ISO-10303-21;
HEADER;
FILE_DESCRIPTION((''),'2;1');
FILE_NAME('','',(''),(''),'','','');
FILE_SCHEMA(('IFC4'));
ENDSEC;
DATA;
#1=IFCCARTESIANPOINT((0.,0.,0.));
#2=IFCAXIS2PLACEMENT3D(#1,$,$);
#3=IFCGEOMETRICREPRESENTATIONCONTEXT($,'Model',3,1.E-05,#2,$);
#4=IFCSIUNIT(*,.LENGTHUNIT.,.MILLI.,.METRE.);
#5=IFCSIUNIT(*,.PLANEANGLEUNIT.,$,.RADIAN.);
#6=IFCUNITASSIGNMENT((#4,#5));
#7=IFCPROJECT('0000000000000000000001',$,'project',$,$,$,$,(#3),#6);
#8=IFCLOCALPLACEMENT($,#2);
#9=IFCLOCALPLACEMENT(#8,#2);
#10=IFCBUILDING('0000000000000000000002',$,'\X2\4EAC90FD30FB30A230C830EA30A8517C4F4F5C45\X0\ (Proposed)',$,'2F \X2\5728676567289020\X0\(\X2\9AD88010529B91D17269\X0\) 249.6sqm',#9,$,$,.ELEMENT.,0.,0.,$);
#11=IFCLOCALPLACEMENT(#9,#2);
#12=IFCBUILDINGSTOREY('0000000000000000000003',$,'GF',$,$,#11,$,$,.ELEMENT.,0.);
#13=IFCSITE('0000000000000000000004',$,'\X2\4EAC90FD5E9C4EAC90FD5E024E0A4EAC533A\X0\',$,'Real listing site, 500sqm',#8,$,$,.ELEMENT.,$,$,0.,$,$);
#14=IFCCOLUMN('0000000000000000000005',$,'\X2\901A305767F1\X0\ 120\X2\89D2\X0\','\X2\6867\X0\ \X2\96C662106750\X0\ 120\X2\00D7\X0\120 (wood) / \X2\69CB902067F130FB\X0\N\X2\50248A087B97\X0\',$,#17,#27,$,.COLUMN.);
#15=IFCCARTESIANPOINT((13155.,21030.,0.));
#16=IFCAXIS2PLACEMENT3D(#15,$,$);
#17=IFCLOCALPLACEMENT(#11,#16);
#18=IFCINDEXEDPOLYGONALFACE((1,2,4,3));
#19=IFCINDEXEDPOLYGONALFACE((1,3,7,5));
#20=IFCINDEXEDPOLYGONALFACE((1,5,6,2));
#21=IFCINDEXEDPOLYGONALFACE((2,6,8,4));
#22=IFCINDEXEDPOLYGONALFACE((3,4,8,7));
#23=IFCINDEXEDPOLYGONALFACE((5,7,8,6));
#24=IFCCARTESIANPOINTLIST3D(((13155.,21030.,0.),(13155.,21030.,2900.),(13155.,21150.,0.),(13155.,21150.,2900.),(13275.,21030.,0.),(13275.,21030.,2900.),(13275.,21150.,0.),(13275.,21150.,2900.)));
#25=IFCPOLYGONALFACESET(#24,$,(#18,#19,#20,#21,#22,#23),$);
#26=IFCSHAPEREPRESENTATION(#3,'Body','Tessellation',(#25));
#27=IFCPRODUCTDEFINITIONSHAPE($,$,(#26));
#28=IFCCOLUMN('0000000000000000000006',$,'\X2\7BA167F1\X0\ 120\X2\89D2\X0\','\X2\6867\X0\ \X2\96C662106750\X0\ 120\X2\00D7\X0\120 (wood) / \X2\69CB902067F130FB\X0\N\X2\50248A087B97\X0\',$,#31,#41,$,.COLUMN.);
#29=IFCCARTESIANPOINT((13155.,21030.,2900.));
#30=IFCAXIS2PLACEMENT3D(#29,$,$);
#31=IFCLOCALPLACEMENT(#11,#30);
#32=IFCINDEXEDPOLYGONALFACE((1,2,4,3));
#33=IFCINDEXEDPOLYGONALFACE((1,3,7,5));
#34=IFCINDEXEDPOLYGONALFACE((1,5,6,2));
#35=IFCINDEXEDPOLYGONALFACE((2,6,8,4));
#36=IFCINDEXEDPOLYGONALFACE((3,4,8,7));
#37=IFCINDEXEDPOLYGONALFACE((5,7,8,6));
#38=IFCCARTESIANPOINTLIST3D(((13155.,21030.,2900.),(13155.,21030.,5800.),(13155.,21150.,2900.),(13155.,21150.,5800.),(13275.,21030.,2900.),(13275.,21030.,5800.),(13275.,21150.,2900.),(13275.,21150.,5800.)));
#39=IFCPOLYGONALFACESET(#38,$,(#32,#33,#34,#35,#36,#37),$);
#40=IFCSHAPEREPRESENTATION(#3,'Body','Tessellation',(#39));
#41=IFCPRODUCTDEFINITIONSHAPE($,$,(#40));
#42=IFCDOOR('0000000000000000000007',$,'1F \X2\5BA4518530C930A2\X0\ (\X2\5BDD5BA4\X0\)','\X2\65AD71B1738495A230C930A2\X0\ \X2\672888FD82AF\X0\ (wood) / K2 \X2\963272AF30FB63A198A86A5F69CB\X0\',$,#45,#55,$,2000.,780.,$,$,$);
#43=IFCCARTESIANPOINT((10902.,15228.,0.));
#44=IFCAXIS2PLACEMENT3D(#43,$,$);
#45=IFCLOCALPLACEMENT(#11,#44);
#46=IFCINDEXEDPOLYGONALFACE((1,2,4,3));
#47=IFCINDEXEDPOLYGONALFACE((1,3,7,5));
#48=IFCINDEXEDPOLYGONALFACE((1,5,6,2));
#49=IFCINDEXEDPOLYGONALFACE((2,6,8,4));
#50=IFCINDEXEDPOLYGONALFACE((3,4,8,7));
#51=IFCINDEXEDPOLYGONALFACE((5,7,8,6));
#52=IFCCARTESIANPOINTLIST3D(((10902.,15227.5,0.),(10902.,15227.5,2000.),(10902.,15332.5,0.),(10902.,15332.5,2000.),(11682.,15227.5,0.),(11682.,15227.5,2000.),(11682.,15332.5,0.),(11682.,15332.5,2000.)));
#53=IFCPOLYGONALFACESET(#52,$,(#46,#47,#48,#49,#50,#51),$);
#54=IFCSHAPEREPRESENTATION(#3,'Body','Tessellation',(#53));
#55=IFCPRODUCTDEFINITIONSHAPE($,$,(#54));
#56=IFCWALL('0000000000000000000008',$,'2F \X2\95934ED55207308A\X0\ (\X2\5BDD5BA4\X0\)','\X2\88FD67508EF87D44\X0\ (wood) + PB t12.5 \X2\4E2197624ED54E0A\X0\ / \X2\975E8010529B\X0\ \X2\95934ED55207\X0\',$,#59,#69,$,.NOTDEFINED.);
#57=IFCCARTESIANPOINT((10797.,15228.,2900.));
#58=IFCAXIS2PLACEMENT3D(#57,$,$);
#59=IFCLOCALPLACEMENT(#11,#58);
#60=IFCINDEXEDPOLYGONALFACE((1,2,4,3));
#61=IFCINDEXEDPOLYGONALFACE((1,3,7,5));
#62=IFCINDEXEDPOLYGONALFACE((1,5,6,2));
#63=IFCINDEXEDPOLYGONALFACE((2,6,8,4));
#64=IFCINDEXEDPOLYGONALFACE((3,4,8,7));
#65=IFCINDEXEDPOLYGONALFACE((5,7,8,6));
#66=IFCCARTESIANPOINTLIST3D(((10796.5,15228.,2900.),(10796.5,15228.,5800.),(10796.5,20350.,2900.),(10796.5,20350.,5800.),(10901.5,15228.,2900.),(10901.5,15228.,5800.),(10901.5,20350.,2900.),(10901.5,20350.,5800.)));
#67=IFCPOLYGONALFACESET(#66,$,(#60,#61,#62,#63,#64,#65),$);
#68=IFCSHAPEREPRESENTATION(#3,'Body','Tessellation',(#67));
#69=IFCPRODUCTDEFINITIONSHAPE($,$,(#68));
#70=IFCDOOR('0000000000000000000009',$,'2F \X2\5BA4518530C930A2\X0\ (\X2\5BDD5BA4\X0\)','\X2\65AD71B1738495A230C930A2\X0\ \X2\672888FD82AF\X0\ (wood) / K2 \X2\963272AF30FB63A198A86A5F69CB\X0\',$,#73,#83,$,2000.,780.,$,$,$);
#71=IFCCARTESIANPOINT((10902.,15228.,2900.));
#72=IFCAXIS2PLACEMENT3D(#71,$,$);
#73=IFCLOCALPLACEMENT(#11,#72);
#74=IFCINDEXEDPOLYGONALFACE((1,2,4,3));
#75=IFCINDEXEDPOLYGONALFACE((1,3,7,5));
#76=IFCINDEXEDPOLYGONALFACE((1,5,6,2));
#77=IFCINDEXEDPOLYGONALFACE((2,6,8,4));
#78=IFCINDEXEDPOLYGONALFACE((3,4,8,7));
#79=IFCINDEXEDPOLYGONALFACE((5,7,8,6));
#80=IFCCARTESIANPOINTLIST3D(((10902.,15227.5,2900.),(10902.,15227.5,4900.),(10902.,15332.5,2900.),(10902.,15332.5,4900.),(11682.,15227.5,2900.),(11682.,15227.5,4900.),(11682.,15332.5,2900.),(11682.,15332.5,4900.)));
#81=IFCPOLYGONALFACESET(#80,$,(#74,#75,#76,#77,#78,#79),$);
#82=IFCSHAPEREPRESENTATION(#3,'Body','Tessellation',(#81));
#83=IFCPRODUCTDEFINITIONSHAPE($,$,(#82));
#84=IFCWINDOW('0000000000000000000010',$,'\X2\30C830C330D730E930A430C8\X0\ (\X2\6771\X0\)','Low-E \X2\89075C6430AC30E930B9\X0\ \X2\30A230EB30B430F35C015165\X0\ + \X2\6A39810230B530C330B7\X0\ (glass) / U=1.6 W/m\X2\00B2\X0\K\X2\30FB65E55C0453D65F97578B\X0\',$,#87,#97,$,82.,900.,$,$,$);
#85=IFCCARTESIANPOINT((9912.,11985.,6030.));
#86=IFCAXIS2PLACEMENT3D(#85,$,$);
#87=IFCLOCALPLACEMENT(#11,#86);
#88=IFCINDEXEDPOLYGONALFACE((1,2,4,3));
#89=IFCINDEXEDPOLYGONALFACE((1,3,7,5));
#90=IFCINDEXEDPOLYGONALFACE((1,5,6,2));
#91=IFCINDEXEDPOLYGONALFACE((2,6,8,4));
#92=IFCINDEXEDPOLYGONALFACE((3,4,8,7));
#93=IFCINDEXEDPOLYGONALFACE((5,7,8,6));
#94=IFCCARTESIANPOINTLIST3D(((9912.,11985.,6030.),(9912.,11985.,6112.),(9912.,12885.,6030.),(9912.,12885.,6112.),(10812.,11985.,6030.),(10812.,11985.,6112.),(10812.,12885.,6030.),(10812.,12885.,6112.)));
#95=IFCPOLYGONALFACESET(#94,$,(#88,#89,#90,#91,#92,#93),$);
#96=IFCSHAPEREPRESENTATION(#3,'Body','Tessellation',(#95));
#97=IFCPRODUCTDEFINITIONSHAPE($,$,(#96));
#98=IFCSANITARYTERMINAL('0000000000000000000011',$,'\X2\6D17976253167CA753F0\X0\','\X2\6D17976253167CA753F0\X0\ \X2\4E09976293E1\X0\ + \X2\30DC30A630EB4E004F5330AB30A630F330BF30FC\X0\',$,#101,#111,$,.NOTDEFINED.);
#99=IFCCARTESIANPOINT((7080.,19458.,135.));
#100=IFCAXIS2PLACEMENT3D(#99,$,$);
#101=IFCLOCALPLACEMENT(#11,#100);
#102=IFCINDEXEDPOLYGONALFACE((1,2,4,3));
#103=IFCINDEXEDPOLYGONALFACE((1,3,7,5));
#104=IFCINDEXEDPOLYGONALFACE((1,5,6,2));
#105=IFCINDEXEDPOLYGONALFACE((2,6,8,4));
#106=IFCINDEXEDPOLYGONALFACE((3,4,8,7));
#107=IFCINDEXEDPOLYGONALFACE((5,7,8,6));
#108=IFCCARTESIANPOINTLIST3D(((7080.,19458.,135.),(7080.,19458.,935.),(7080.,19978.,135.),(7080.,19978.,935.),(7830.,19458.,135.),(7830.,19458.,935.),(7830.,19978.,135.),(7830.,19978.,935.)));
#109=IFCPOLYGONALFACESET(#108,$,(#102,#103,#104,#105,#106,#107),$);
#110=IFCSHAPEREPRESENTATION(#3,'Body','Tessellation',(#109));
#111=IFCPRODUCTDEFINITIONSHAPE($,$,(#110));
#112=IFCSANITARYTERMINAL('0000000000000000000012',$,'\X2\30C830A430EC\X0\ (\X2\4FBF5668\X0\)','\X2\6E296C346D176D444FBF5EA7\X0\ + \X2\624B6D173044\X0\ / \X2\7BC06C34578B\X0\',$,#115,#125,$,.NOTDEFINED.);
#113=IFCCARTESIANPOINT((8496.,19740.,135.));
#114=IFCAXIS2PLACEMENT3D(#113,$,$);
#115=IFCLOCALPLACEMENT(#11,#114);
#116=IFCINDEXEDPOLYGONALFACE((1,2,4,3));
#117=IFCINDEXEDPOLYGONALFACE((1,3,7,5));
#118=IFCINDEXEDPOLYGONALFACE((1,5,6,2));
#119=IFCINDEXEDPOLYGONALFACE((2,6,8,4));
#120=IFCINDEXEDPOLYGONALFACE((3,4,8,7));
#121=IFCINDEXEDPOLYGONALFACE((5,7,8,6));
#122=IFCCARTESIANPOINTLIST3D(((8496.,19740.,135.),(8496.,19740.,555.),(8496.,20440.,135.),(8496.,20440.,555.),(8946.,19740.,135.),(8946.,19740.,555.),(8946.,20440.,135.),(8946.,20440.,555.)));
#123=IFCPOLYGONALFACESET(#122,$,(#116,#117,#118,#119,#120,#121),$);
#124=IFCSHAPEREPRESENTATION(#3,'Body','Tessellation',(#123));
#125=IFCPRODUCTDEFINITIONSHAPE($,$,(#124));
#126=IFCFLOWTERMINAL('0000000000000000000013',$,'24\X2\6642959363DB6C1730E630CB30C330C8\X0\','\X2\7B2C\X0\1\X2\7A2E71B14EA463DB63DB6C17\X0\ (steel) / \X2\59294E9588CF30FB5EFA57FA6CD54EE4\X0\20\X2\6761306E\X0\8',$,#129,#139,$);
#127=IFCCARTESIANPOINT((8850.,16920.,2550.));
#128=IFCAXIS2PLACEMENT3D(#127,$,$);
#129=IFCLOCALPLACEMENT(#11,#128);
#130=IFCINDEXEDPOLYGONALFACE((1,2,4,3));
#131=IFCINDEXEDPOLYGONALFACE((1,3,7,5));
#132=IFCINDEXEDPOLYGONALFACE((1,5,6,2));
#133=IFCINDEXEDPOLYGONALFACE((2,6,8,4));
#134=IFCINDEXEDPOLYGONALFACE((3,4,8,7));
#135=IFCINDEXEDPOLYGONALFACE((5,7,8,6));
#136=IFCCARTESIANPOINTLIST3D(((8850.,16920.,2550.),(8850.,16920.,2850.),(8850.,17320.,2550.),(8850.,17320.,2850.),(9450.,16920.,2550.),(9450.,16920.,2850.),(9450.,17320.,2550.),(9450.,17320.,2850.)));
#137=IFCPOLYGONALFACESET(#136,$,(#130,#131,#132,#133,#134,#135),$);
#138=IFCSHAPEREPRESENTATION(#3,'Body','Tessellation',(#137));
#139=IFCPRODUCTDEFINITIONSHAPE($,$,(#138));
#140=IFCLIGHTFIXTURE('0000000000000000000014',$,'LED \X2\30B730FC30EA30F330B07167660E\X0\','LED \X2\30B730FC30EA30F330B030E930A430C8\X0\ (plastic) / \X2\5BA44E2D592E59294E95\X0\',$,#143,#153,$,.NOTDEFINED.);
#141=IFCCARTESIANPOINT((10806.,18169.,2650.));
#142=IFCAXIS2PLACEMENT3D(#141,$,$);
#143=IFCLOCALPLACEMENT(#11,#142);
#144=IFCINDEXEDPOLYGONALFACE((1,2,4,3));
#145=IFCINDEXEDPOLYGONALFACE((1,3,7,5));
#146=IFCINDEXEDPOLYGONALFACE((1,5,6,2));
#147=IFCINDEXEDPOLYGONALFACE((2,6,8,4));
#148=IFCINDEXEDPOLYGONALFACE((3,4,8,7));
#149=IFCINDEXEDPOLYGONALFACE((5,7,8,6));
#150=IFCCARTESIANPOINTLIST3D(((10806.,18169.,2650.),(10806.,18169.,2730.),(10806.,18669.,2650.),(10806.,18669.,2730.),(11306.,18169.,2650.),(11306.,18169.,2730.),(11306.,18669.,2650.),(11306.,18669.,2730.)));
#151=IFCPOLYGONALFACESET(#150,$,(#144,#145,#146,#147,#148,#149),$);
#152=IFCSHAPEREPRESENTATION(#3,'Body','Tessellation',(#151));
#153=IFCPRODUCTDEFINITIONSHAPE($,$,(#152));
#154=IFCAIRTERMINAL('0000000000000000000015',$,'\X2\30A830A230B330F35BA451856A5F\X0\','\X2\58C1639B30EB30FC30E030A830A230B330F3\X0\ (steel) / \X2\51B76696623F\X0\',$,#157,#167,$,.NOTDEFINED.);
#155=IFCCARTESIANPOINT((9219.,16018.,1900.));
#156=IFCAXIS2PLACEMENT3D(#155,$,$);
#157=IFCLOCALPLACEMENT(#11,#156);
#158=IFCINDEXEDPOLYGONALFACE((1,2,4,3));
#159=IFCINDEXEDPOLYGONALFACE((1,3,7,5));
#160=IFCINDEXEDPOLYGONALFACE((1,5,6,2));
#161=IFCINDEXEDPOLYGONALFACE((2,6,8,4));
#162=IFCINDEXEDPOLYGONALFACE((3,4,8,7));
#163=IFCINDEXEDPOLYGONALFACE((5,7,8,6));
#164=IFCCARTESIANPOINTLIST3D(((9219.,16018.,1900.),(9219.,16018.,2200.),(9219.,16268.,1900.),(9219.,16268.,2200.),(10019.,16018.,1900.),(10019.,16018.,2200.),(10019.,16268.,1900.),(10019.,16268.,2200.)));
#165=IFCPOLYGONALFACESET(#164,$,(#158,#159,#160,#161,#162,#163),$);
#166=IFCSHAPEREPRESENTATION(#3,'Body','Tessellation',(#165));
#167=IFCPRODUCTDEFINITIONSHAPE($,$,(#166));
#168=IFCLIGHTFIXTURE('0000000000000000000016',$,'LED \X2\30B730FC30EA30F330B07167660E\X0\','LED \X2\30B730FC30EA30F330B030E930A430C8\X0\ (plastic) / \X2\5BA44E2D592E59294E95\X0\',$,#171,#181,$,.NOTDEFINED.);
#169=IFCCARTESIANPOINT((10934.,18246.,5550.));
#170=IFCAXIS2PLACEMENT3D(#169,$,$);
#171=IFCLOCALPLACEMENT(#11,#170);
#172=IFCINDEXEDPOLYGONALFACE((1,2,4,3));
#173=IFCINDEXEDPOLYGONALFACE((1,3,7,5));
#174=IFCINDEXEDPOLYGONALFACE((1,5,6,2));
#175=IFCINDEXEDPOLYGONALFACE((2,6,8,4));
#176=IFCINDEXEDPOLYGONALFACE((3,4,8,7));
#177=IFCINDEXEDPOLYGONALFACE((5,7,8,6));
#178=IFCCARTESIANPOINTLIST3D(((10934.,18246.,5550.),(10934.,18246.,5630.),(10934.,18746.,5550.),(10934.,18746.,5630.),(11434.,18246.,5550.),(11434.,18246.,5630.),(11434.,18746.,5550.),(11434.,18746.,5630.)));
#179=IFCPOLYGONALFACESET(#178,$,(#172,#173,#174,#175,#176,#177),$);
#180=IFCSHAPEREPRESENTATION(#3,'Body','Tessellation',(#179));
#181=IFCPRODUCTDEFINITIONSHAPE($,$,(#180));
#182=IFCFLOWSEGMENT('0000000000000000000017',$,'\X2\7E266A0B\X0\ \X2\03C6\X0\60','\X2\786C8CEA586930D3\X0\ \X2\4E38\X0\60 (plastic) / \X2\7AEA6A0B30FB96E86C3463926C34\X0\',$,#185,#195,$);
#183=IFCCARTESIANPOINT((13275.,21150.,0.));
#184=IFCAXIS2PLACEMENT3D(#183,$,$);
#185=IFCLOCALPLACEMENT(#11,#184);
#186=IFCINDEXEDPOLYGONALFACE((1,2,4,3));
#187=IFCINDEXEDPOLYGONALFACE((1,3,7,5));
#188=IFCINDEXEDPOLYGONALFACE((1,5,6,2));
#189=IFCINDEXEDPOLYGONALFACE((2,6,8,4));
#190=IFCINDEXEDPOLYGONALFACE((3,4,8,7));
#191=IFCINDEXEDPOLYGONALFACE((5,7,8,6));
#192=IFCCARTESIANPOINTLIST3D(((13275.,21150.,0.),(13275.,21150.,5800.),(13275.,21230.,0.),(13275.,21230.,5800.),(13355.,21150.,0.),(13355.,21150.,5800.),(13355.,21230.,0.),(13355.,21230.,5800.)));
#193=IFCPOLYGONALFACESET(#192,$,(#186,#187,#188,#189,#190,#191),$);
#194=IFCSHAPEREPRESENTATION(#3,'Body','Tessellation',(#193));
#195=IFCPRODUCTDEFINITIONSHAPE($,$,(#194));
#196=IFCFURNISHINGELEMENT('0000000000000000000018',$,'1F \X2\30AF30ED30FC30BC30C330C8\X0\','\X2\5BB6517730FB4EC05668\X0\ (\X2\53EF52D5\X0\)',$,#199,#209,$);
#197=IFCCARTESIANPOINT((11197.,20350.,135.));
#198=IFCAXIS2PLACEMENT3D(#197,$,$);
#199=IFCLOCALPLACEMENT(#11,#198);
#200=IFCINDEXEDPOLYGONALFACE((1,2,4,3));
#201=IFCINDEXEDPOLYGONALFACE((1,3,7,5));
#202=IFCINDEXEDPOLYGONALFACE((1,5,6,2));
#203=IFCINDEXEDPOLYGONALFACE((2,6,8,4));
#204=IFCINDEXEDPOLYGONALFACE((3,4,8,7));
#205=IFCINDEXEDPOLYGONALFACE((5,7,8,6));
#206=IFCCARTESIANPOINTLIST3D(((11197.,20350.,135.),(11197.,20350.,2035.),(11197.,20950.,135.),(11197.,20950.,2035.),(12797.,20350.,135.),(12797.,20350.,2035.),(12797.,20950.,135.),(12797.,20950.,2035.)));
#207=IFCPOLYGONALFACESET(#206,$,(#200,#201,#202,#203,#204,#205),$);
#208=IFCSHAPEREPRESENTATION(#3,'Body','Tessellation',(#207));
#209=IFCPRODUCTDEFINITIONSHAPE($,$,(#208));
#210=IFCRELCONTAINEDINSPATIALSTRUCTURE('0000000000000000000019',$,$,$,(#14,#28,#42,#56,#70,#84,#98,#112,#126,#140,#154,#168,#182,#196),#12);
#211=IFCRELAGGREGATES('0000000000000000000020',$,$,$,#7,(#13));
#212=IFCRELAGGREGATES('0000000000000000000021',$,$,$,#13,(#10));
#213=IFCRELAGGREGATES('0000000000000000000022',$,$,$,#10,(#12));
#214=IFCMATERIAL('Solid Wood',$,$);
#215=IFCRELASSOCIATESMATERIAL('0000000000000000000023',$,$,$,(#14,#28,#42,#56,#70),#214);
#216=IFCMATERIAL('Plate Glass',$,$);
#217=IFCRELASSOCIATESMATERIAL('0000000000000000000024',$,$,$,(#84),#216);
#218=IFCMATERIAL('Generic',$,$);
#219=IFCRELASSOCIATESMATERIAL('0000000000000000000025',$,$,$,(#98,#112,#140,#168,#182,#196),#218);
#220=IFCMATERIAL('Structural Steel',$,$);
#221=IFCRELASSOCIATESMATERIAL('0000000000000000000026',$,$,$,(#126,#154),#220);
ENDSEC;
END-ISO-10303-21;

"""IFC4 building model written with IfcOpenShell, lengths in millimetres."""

from ifc_helpers import new_model, si_unit, frame, frame_2d, origin, place, context, project, spatial, rectangle, extrude, material, element, save


model = new_model("IFC4")

# Units and contexts
model_context = context("Model", 3, precision=1e-05, world=origin())
ifc_project = project(units=[si_unit("LENGTHUNIT", "METRE", prefix="MILLI"), si_unit("PLANEANGLEUNIT", "RADIAN")], contexts=[model_context])

# Site, building, storey
site_placement = place(None, origin())
site = spatial("IfcSite", under=ifc_project, at=site_placement, Name="京都府京都市上京区", ObjectType="Real listing site, 500sqm", CompositionType="ELEMENT", RefElevation=0.0)
building_placement = place(site_placement, origin())
building = spatial("IfcBuilding", under=site, at=building_placement, Name="京都・アトリエ兼住居 (Proposed)", ObjectType="2F 在来木造(高耐力金物) 249.6sqm", CompositionType="ELEMENT", ElevationOfRefHeight=0.0, ElevationOfTerrain=0.0)
storey_placement = place(building_placement, origin())
storey = spatial("IfcBuildingStorey", under=building, at=storey_placement, Name="GF", CompositionType="ELEMENT", Elevation=0.0)

# Columns
ifc_material_1 = material(Name="Solid Wood")
column_1_placement = place(storey_placement, frame((13155.0, 21030.0, 0.0)))
element("IfcColumn", 1, at=column_1_placement, inside=storey, material=ifc_material_1, Name="通し柱 120角", Description="桧 集成材 120×120 (wood) / 構造柱・N値計算", PredefinedType="COLUMN", context=model_context, shape_type="SweptSolid", body=[
    extrude(rectangle(XDim=120.0, YDim=120.0, at=frame_2d((60.0, 60.0))), frame((13155.0, 21030.0, 0.0)), (0.0, 0.0, 1.0), 2900.0),
])
column_2_placement = place(storey_placement, frame((13155.0, 21030.0, 2900.0)))
element("IfcColumn", 2, at=column_2_placement, inside=storey, material=ifc_material_1, Name="管柱 120角", Description="桧 集成材 120×120 (wood) / 構造柱・N値計算", PredefinedType="COLUMN", context=model_context, shape_type="SweptSolid", body=[
    extrude(rectangle(XDim=120.0, YDim=120.0, at=frame_2d((60.0, 60.0))), frame((13155.0, 21030.0, 2900.0)), (0.0, 0.0, 1.0), 2900.0),
])

# Door
door_1_placement = place(storey_placement, frame((10902.0, 15228.0, 0.0)))
element("IfcDoor", 3, at=door_1_placement, inside=storey, material=ifc_material_1, Name="1F 室内ドア (寝室)", Description="断熱玄関ドア 木製芯 (wood) / K2 防犯・採風機構", OverallHeight=2000.0, OverallWidth=780.0, context=model_context, shape_type="SweptSolid", body=[
    extrude(rectangle(XDim=780.0, YDim=105.0, at=frame_2d((390.0, 52.0))), frame((10902.0, 15228.0, 0.0)), (0.0, 0.0, 1.0), 2000.0),
])

# Wall
wall_1_placement = place(storey_placement, frame((10797.0, 15228.0, 2900.0)))
element("IfcWall", 4, at=wall_1_placement, inside=storey, material=ifc_material_1, Name="2F 間仕切り (寝室)", Description="製材軸組 (wood) + PB t12.5 両面仕上 / 非耐力 間仕切", PredefinedType="NOTDEFINED", context=model_context, shape_type="SweptSolid", body=[
    extrude(rectangle(XDim=105.0, YDim=5122.0, at=frame_2d((52.0, 2561.0))), frame((10797.0, 15228.0, 2900.0)), (0.0, 0.0, 1.0), 2900.0),
])

# Door
door_2_placement = place(storey_placement, frame((10902.0, 15228.0, 2900.0)))
element("IfcDoor", 5, at=door_2_placement, inside=storey, material=ifc_material_1, Name="2F 室内ドア (寝室)", Description="断熱玄関ドア 木製芯 (wood) / K2 防犯・採風機構", OverallHeight=2000.0, OverallWidth=780.0, context=model_context, shape_type="SweptSolid", body=[
    extrude(rectangle(XDim=780.0, YDim=105.0, at=frame_2d((390.0, 52.0))), frame((10902.0, 15228.0, 2900.0)), (0.0, 0.0, 1.0), 2000.0),
])

# Window
ifc_material_2 = material(Name="Plate Glass")
window_placement = place(storey_placement, frame((9912.0, 11985.0, 6030.0)))
element("IfcWindow", 6, at=window_placement, inside=storey, material=ifc_material_2, Name="トップライト (東)", Description="Low-E 複層ガラス アルゴン封入 + 樹脂サッシ (glass) / U=1.6 W/m²K・日射取得型", OverallHeight=82.0, OverallWidth=900.0, context=model_context, shape_type="SweptSolid", body=[
    extrude(rectangle(XDim=900.0, YDim=900.0, at=frame_2d((450.0, 450.0))), frame((9912.0, 11985.0, 6030.0)), (0.0, 0.0, 1.0), 82.0),
])

# Sanitary terminals
ifc_material_3 = material(Name="Generic")
sanitary_terminal_1_placement = place(storey_placement, frame((7080.0, 19458.0, 135.0)))
element("IfcSanitaryTerminal", 7, at=sanitary_terminal_1_placement, inside=storey, material=ifc_material_3, Name="洗面化粧台", Description="洗面化粧台 三面鏡 + ボウル一体カウンター", PredefinedType="NOTDEFINED", context=model_context, shape_type="SweptSolid", body=[
    extrude(rectangle(XDim=750.0, YDim=520.0, at=frame_2d((375.0, 260.0))), frame((7080.0, 19458.0, 135.0)), (0.0, 0.0, 1.0), 800.0),
])
sanitary_terminal_2_placement = place(storey_placement, frame((8496.0, 19740.0, 135.0)))
element("IfcSanitaryTerminal", 8, at=sanitary_terminal_2_placement, inside=storey, material=ifc_material_3, Name="トイレ (便器)", Description="温水洗浄便座 + 手洗い / 節水型", PredefinedType="NOTDEFINED", context=model_context, shape_type="SweptSolid", body=[
    extrude(rectangle(XDim=450.0, YDim=700.0, at=frame_2d((225.0, 350.0))), frame((8496.0, 19740.0, 135.0)), (0.0, 0.0, 1.0), 420.0),
])

# Flow terminal
ifc_material_4 = material(Name="Structural Steel")
flow_terminal_placement = place(storey_placement, frame((8850.0, 16920.0, 2550.0)))
element("IfcFlowTerminal", 9, at=flow_terminal_placement, inside=storey, material=ifc_material_4, Name="24時間換気ユニット", Description="第1種熱交換換気 (steel) / 天井裏・建基法令20条の8", context=model_context, shape_type="SweptSolid", body=[
    extrude(rectangle(XDim=600.0, YDim=400.0, at=frame_2d((300.0, 200.0))), frame((8850.0, 16920.0, 2550.0)), (0.0, 0.0, 1.0), 300.0),
])

# Light fixture
light_fixture_1_placement = place(storey_placement, frame((10806.0, 18169.0, 2650.0)))
element("IfcLightFixture", 10, at=light_fixture_1_placement, inside=storey, material=ifc_material_3, Name="LED シーリング照明", Description="LED シーリングライト (plastic) / 室中央天井", PredefinedType="NOTDEFINED", context=model_context, shape_type="SweptSolid", body=[
    extrude(rectangle(XDim=500.0, YDim=500.0, at=frame_2d((250.0, 250.0))), frame((10806.0, 18169.0, 2650.0)), (0.0, 0.0, 1.0), 80.0),
])

# Air terminal
air_terminal_placement = place(storey_placement, frame((9219.0, 16018.0, 1900.0)))
element("IfcAirTerminal", 11, at=air_terminal_placement, inside=storey, material=ifc_material_4, Name="エアコン室内機", Description="壁掛ルームエアコン (steel) / 冷暖房", PredefinedType="NOTDEFINED", context=model_context, shape_type="SweptSolid", body=[
    extrude(rectangle(XDim=800.0, YDim=250.0, at=frame_2d((400.0, 125.0))), frame((9219.0, 16018.0, 1900.0)), (0.0, 0.0, 1.0), 300.0),
])

# Light fixture
light_fixture_2_placement = place(storey_placement, frame((10934.0, 18246.0, 5550.0)))
element("IfcLightFixture", 12, at=light_fixture_2_placement, inside=storey, material=ifc_material_3, Name="LED シーリング照明", Description="LED シーリングライト (plastic) / 室中央天井", PredefinedType="NOTDEFINED", context=model_context, shape_type="SweptSolid", body=[
    extrude(rectangle(XDim=500.0, YDim=500.0, at=frame_2d((250.0, 250.0))), frame((10934.0, 18246.0, 5550.0)), (0.0, 0.0, 1.0), 80.0),
])

# Flow segment
flow_segment_placement = place(storey_placement, frame((13275.0, 21150.0, 0.0)))
element("IfcFlowSegment", 13, at=flow_segment_placement, inside=storey, material=ifc_material_3, Name="縦樋 φ60", Description="硬質塩ビ 丸60 (plastic) / 竪樋・雨水排水", context=model_context, shape_type="SweptSolid", body=[
    extrude(rectangle(XDim=80.0, YDim=80.0, at=frame_2d((40.0, 40.0))), frame((13275.0, 21150.0, 0.0)), (0.0, 0.0, 1.0), 5800.0),
])

# Furnishing element
furnishing_1_placement = place(storey_placement, frame((11197.0, 20350.0, 135.0)))
element("IfcFurnishingElement", 14, at=furnishing_1_placement, inside=storey, material=ifc_material_3, Name="1F クローゼット", Description="家具・什器 (可動)", context=model_context, shape_type="SweptSolid", body=[
    extrude(rectangle(XDim=1600.0, YDim=600.0, at=frame_2d((800.0, 300.0))), frame((11197.0, 20350.0, 135.0)), (0.0, 0.0, 1.0), 1900.0),
])

save(model, "model.ifc")
